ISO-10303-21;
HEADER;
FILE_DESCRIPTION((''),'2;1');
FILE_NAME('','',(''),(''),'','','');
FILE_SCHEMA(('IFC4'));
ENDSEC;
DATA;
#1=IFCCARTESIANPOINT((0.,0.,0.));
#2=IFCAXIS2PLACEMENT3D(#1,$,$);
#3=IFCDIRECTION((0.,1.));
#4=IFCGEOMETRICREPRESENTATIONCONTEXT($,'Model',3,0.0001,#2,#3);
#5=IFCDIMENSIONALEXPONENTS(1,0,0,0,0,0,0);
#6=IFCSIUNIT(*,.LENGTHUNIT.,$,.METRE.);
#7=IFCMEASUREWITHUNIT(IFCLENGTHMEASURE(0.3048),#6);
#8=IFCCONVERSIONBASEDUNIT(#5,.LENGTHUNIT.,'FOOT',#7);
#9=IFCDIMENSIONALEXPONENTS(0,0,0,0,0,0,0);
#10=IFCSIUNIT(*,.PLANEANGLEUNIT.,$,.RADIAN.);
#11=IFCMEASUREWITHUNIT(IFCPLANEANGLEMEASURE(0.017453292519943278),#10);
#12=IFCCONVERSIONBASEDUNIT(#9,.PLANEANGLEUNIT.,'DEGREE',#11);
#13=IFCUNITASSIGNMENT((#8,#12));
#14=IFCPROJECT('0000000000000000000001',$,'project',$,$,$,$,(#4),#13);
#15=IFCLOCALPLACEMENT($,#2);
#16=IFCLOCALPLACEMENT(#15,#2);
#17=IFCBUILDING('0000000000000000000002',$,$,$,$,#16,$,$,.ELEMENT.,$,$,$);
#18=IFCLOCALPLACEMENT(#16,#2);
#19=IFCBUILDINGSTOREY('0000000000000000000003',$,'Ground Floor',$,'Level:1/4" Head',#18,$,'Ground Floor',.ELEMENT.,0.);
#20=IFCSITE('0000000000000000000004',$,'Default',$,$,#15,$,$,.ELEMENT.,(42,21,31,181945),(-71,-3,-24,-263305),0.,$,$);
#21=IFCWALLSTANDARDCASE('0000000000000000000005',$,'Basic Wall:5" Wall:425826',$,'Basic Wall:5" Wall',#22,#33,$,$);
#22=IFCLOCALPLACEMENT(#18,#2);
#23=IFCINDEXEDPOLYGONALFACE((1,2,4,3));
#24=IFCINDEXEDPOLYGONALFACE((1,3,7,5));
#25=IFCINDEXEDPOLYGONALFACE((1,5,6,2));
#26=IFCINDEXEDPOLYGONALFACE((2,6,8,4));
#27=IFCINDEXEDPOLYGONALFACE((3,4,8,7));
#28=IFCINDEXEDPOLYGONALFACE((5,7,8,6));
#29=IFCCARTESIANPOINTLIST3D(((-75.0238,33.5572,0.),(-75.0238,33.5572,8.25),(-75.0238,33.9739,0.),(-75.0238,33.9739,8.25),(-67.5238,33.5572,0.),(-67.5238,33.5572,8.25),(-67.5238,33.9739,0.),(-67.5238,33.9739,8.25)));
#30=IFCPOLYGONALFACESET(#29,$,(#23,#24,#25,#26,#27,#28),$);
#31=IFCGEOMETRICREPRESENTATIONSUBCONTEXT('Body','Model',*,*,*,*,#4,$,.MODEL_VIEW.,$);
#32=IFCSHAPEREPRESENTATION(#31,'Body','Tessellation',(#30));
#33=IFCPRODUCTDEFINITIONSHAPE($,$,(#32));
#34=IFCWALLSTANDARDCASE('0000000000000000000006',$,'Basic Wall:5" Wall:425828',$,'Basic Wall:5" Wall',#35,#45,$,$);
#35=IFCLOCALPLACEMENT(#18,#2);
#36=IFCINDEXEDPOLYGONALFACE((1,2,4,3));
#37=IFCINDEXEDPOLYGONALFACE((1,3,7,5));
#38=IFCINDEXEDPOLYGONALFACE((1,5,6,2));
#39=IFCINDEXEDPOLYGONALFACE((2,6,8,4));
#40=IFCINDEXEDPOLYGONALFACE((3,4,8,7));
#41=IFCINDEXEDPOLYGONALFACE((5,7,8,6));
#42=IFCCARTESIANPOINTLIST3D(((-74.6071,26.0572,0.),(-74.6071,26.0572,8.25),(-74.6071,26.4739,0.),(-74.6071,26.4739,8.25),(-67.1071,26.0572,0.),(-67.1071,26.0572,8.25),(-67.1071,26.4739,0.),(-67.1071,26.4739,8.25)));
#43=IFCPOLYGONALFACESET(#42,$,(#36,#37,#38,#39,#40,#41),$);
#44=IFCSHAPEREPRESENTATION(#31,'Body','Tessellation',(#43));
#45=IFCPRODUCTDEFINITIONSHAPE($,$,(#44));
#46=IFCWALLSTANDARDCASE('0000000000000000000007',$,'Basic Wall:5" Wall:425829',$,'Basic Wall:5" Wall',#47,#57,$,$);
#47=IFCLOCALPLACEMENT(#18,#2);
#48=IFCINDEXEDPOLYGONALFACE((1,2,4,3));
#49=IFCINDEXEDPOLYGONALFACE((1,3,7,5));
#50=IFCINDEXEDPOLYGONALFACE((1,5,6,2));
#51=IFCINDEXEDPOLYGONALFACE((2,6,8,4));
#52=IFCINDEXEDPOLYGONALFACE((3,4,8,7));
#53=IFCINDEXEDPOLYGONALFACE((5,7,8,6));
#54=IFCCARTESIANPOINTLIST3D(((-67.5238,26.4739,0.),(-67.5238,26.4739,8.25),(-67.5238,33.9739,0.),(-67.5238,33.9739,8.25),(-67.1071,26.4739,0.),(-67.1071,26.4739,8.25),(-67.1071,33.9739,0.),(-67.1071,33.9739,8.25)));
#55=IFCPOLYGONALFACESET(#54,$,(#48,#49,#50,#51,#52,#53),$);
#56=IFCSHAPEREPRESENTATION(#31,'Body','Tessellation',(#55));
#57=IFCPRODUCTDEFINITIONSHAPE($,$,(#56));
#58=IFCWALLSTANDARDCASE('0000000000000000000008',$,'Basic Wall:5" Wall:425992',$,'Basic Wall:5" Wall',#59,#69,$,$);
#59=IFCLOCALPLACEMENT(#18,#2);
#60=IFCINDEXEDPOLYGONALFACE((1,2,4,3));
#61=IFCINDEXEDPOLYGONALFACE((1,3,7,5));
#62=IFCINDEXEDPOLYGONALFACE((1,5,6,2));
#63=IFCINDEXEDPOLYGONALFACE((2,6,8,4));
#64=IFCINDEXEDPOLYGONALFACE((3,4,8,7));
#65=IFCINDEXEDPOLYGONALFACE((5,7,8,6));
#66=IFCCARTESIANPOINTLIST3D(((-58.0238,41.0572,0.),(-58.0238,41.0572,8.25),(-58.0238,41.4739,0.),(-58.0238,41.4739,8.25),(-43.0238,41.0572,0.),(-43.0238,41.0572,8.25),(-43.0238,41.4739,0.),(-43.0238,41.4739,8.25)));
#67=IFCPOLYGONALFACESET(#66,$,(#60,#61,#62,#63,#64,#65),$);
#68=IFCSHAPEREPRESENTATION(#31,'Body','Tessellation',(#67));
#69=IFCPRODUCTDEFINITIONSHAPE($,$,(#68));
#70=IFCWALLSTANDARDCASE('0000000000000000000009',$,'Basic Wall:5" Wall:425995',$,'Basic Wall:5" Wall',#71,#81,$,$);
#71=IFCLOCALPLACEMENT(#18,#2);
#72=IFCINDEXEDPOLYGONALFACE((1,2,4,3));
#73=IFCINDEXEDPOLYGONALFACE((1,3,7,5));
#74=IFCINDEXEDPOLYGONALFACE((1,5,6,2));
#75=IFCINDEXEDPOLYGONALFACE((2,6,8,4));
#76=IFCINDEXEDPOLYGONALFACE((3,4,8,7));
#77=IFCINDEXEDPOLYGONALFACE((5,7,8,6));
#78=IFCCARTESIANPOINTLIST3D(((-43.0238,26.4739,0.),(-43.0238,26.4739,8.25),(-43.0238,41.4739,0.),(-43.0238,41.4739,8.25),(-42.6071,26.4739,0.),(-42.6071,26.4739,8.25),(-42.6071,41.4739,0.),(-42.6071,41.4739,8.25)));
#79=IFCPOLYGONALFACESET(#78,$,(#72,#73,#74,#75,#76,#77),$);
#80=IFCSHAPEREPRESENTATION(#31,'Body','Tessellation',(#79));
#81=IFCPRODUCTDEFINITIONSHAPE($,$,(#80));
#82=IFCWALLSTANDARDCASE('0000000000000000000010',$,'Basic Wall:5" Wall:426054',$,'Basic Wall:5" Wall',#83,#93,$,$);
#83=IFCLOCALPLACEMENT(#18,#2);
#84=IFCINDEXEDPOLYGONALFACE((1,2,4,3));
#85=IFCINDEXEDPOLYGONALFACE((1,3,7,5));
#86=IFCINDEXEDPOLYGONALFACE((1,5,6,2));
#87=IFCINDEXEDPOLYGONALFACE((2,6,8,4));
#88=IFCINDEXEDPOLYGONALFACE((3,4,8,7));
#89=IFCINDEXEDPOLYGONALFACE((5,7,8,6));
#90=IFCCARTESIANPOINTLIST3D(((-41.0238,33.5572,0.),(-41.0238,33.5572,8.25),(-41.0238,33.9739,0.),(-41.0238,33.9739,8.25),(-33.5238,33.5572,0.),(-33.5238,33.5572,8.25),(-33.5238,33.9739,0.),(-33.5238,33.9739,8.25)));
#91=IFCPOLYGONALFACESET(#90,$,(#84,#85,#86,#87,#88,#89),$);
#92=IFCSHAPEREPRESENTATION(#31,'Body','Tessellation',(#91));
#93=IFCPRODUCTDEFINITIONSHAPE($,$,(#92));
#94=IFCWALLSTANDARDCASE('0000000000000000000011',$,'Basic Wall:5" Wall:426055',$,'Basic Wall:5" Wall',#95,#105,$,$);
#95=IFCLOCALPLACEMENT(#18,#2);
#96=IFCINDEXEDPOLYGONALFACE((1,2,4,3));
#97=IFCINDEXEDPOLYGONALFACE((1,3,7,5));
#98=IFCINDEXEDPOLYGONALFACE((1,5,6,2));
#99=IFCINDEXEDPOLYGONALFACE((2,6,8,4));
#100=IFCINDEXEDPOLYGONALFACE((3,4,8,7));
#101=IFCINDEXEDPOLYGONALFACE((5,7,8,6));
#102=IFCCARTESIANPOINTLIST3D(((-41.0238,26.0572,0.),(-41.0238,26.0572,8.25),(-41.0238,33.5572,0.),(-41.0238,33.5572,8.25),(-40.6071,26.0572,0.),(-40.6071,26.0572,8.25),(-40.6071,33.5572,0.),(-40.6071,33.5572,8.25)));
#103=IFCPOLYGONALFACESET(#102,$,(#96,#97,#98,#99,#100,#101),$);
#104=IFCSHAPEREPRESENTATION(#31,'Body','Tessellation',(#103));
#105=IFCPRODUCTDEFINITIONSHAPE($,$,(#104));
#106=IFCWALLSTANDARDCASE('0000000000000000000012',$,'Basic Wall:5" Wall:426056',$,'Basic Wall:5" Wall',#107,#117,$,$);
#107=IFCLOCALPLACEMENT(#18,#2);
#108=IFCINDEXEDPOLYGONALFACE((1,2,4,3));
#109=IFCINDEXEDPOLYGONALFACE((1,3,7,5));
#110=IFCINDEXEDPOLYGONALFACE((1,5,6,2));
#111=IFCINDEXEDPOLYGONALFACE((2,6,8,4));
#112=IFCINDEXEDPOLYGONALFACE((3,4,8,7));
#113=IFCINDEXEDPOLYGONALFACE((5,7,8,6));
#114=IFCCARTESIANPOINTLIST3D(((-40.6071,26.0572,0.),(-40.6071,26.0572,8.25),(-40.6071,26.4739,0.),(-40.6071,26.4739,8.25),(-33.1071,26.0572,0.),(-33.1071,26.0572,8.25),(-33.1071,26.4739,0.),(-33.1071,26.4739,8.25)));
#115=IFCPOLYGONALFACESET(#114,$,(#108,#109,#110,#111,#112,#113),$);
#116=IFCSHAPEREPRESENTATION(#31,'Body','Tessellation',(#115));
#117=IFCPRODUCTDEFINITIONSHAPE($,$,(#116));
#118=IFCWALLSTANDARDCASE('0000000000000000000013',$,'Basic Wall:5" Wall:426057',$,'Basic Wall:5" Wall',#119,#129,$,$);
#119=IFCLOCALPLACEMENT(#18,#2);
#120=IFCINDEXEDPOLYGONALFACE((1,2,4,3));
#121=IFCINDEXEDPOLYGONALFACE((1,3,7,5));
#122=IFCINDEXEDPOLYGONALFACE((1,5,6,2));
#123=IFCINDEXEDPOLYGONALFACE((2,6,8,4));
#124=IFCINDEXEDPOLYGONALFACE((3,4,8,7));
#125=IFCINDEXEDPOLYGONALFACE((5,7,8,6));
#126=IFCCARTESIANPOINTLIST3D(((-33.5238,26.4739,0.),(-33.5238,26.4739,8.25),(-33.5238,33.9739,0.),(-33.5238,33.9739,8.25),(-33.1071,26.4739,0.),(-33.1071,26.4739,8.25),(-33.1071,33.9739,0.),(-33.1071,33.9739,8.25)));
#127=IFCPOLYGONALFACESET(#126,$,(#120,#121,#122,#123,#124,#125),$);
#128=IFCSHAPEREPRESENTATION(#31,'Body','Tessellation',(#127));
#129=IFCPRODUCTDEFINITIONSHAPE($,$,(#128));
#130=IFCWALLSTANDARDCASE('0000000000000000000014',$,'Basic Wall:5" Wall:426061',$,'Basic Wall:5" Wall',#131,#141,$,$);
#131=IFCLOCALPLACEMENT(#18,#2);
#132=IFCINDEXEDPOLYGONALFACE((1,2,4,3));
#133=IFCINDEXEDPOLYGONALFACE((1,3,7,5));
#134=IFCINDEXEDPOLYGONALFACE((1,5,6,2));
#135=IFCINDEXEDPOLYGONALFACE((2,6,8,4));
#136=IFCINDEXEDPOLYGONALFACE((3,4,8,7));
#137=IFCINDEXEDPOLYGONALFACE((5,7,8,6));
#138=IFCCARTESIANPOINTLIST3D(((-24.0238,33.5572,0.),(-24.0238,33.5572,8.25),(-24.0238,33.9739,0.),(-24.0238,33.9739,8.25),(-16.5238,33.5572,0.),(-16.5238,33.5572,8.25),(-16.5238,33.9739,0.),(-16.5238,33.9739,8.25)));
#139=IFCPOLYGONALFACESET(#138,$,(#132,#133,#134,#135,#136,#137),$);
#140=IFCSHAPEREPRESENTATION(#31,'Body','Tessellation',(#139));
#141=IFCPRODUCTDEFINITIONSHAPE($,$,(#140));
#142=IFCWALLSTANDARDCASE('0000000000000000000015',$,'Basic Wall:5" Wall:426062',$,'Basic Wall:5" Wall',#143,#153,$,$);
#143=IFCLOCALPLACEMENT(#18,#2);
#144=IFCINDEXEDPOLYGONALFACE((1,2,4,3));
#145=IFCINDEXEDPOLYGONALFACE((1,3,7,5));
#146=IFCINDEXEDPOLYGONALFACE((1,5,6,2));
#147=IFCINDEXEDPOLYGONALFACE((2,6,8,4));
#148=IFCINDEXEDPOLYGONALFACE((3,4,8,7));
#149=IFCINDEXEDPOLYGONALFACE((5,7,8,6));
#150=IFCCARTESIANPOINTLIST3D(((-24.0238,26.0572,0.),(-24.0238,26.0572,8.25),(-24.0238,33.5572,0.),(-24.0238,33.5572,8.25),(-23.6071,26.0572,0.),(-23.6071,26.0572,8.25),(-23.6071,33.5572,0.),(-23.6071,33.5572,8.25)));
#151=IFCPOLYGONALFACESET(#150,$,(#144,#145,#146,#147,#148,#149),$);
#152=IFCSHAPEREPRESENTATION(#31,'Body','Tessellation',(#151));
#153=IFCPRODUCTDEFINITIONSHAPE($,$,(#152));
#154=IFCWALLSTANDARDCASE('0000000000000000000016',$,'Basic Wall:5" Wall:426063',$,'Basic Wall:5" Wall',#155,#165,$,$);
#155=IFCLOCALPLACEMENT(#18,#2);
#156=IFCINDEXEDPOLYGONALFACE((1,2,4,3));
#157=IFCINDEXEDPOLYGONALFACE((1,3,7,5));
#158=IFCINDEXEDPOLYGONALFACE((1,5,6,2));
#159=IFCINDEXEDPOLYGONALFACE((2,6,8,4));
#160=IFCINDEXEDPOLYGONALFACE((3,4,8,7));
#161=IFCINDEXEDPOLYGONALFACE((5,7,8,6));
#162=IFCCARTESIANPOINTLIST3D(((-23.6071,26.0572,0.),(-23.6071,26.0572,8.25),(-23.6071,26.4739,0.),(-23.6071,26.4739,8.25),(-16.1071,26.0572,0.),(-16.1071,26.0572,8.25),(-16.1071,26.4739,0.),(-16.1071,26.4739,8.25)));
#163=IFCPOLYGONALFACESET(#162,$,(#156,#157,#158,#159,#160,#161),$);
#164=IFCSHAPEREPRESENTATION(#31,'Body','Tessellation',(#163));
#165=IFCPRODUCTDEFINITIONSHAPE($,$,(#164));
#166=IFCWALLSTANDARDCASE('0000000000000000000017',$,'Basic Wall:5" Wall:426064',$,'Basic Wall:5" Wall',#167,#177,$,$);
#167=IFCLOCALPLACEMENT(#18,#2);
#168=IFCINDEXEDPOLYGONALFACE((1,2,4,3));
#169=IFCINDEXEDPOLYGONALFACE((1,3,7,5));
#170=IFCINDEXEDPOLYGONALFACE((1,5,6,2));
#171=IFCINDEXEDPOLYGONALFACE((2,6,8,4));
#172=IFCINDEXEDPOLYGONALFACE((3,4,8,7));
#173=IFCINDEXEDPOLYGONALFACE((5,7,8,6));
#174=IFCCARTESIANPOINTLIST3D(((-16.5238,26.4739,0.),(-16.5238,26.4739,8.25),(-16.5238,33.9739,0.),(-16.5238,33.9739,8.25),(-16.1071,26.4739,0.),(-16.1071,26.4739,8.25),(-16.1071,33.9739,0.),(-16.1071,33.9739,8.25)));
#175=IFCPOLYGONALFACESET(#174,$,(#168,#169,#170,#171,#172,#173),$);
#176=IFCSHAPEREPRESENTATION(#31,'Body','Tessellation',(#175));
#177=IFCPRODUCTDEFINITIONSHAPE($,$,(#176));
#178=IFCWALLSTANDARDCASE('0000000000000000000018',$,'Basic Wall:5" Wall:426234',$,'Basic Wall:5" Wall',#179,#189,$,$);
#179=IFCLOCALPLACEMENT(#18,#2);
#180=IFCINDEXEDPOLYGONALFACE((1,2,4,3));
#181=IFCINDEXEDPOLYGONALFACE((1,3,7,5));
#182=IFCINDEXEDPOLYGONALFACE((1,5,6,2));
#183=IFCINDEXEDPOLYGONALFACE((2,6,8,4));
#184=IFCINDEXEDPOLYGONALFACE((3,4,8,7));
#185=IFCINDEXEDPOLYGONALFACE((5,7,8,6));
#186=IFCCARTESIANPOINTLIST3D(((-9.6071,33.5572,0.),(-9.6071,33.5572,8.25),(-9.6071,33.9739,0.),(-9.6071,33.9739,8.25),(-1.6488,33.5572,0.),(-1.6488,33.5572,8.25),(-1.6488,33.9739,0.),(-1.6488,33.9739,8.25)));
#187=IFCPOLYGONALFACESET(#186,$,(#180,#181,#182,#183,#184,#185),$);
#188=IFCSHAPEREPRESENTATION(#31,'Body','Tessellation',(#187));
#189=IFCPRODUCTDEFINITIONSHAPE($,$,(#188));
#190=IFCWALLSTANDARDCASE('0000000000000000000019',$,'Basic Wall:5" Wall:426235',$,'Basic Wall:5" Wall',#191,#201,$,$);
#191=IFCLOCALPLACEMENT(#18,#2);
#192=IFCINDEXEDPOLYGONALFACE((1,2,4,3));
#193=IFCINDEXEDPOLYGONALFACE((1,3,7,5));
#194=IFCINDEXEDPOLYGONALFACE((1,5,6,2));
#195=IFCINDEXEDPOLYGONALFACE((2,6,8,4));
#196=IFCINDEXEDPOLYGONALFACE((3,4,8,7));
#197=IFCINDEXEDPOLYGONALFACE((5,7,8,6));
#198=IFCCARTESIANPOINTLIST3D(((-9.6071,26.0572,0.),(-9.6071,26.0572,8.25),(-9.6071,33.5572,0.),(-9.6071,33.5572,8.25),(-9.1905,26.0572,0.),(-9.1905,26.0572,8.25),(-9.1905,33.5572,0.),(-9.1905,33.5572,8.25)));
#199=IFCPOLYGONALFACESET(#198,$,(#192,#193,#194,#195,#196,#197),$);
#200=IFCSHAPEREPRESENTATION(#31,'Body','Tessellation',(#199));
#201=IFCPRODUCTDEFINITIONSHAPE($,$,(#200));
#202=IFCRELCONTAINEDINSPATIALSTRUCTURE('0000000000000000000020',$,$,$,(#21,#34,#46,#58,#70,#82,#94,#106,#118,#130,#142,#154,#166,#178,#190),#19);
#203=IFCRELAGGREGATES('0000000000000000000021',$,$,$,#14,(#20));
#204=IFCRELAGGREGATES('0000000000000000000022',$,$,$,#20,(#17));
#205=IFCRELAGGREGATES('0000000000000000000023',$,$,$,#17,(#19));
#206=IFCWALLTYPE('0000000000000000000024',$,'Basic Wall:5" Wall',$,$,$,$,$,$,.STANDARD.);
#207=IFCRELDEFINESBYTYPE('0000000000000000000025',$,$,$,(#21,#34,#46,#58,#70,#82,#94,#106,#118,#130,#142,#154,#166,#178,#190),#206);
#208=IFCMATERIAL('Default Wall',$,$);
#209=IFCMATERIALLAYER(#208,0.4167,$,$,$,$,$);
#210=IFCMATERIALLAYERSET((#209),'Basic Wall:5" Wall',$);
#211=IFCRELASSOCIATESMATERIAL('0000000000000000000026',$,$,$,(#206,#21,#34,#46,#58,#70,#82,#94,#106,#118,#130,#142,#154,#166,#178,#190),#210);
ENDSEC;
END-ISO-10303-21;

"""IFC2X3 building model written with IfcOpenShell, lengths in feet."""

from ifc_helpers import new_model, entity, si_unit, converted_unit, direction, frame, frame_2d, origin, place, context, subcontext, project, spatial, rectangle, extrude, material, layer, layer_set, layer_usage, type_object, element, save


model = new_model("IFC2X3")

# Units and contexts
model_context = context("Model", 3, precision=0.0001, world=origin(), true_north=direction((0.0, 1.0)))
body_context = subcontext(model_context, "Body", "Model", "MODEL_VIEW")
ifc_project = project(units=[converted_unit("LENGTHUNIT", "FOOT", entity("IfcLengthMeasure", 0.3048), si_unit("LENGTHUNIT", "METRE"), dimensions=[1, 0, 0, 0, 0, 0, 0]), converted_unit("PLANEANGLEUNIT", "DEGREE", entity("IfcPlaneAngleMeasure", 0.017453292519943278), si_unit("PLANEANGLEUNIT", "RADIAN"), dimensions=[0, 0, 0, 0, 0, 0, 0])], contexts=[model_context])

# Site, building, storey
site_placement = place(None, origin())
site = spatial("IfcSite", under=ifc_project, at=site_placement, Name="Default", CompositionType="ELEMENT", RefLatitude=(42, 21, 31, 181945), RefLongitude=(-71, -3, -24, -263305), RefElevation=0.0)
building_placement = place(site_placement, origin())
building = spatial("IfcBuilding", under=site, at=building_placement, CompositionType="ELEMENT")
storey_placement = place(building_placement, origin())
storey = spatial("IfcBuildingStorey", under=building, at=storey_placement, Name="Ground Floor", ObjectType="Level:1/4\" Head", LongName="Ground Floor", CompositionType="ELEMENT", Elevation=0.0)

# Walls
ifc_material = material(Name="Default Wall")
ifc_layer = layer(ifc_material, 0.4167)
ifc_layer_set = layer_set([ifc_layer], Name="Basic Wall:5\" Wall")
ifc_layer_usage_1 = layer_usage(ifc_layer_set, "AXIS2", "NEGATIVE", 0.2083)
wall_type = type_object("IfcWallType", Name="Basic Wall:5\" Wall", PredefinedType="STANDARD", material=ifc_layer_set)
wall_1_placement = place(storey_placement, frame((-75.0238, 33.7656, 0.0)))
element("IfcWallStandardCase", 1, at=wall_1_placement, inside=storey, type_object=wall_type, material=ifc_layer_usage_1, Name="Basic Wall:5\" Wall:425826", ObjectType="Basic Wall:5\" Wall", context=body_context, shape_type="SweptSolid", body=[
    extrude(rectangle(XDim=7.5, YDim=0.4167, at=frame_2d((3.75, 0.0), x_axis=(-1.0, 0.0))), origin(), (0.0, 0.0, 1.0), 8.25),
])
wall_2_placement = place(storey_placement, frame((-67.1071, 26.2656, 0.0), z_axis=(0.0, 0.0, 1.0), x_axis=(-1.0, 0.0, 0.0)))
element("IfcWallStandardCase", 2, at=wall_2_placement, inside=storey, type_object=wall_type, material=ifc_layer_usage_1, Name="Basic Wall:5\" Wall:425828", ObjectType="Basic Wall:5\" Wall", context=body_context, shape_type="SweptSolid", body=[
    extrude(rectangle(XDim=7.5, YDim=0.4167, at=frame_2d((3.75, 0.0), x_axis=(-1.0, 0.0))), origin(), (0.0, 0.0, 1.0), 8.25),
])
wall_3_placement = place(storey_placement, frame((-67.3155, 33.9739, 0.0), z_axis=(0.0, 0.0, 1.0), x_axis=(0.0, -1.0, 0.0)))
element("IfcWallStandardCase", 3, at=wall_3_placement, inside=storey, type_object=wall_type, material=ifc_layer_usage_1, Name="Basic Wall:5\" Wall:425829", ObjectType="Basic Wall:5\" Wall", context=body_context, shape_type="SweptSolid", body=[
    extrude(rectangle(XDim=7.5, YDim=0.4167, at=frame_2d((3.75, 0.0), x_axis=(-1.0, 0.0))), origin(), (0.0, 0.0, 1.0), 8.25),
])
wall_4_placement = place(storey_placement, frame((-58.0238, 41.2656, 0.0)))
element("IfcWallStandardCase", 4, at=wall_4_placement, inside=storey, type_object=wall_type, material=ifc_layer_usage_1, Name="Basic Wall:5\" Wall:425992", ObjectType="Basic Wall:5\" Wall", context=body_context, shape_type="SweptSolid", body=[
    extrude(rectangle(XDim=15.0, YDim=0.4167, at=frame_2d((7.5, 0.0), x_axis=(-1.0, 0.0))), origin(), (0.0, 0.0, 1.0), 8.25),
])
wall_5_placement = place(storey_placement, frame((-42.8155, 41.4739, 0.0), z_axis=(0.0, 0.0, 1.0), x_axis=(0.0, -1.0, 0.0)))
element("IfcWallStandardCase", 5, at=wall_5_placement, inside=storey, type_object=wall_type, material=ifc_layer_usage_1, Name="Basic Wall:5\" Wall:425995", ObjectType="Basic Wall:5\" Wall", context=body_context, shape_type="SweptSolid", body=[
    extrude(rectangle(XDim=15.0, YDim=0.4167, at=frame_2d((7.5, 0.0), x_axis=(-1.0, 0.0))), origin(), (0.0, 0.0, 1.0), 8.25),
])
wall_6_placement = place(storey_placement, frame((-41.0238, 33.7656, 0.0)))
element("IfcWallStandardCase", 6, at=wall_6_placement, inside=storey, type_object=wall_type, material=ifc_layer_usage_1, Name="Basic Wall:5\" Wall:426054", ObjectType="Basic Wall:5\" Wall", context=body_context, shape_type="SweptSolid", body=[
    extrude(rectangle(XDim=7.5, YDim=0.4167, at=frame_2d((3.75, 0.0), x_axis=(-1.0, 0.0))), origin(), (0.0, 0.0, 1.0), 8.25),
])
wall_7_placement = place(storey_placement, frame((-40.8155, 26.0572, 0.0), z_axis=(0.0, 0.0, 1.0), x_axis=(0.0, 1.0, 0.0)))
element("IfcWallStandardCase", 7, at=wall_7_placement, inside=storey, type_object=wall_type, material=ifc_layer_usage_1, Name="Basic Wall:5\" Wall:426055", ObjectType="Basic Wall:5\" Wall", context=body_context, shape_type="SweptSolid", body=[
    extrude(rectangle(XDim=7.5, YDim=0.4167, at=frame_2d((3.75, 0.0), x_axis=(-1.0, 0.0))), origin(), (0.0, 0.0, 1.0), 8.25),
])
wall_8_placement = place(storey_placement, frame((-33.1071, 26.2656, 0.0), z_axis=(0.0, 0.0, 1.0), x_axis=(-1.0, 0.0, 0.0)))
element("IfcWallStandardCase", 8, at=wall_8_placement, inside=storey, type_object=wall_type, material=ifc_layer_usage_1, Name="Basic Wall:5\" Wall:426056", ObjectType="Basic Wall:5\" Wall", context=body_context, shape_type="SweptSolid", body=[
    extrude(rectangle(XDim=7.5, YDim=0.4167, at=frame_2d((3.75, 0.0), x_axis=(-1.0, 0.0))), origin(), (0.0, 0.0, 1.0), 8.25),
])
wall_9_placement = place(storey_placement, frame((-33.3155, 33.9739, 0.0), z_axis=(0.0, 0.0, 1.0), x_axis=(0.0, -1.0, 0.0)))
element("IfcWallStandardCase", 9, at=wall_9_placement, inside=storey, type_object=wall_type, material=ifc_layer_usage_1, Name="Basic Wall:5\" Wall:426057", ObjectType="Basic Wall:5\" Wall", context=body_context, shape_type="SweptSolid", body=[
    extrude(rectangle(XDim=7.5, YDim=0.4167, at=frame_2d((3.75, 0.0), x_axis=(-1.0, 0.0))), origin(), (0.0, 0.0, 1.0), 8.25),
])
wall_10_placement = place(storey_placement, frame((-24.0238, 33.7656, 0.0)))
element("IfcWallStandardCase", 10, at=wall_10_placement, inside=storey, type_object=wall_type, material=ifc_layer_usage_1, Name="Basic Wall:5\" Wall:426061", ObjectType="Basic Wall:5\" Wall", context=body_context, shape_type="SweptSolid", body=[
    extrude(rectangle(XDim=7.5, YDim=0.4167, at=frame_2d((3.75, 0.0), x_axis=(-1.0, 0.0))), origin(), (0.0, 0.0, 1.0), 8.25),
])
wall_11_placement = place(storey_placement, frame((-23.8155, 26.0572, 0.0), z_axis=(0.0, 0.0, 1.0), x_axis=(0.0, 1.0, 0.0)))
element("IfcWallStandardCase", 11, at=wall_11_placement, inside=storey, type_object=wall_type, material=ifc_layer_usage_1, Name="Basic Wall:5\" Wall:426062", ObjectType="Basic Wall:5\" Wall", context=body_context, shape_type="SweptSolid", body=[
    extrude(rectangle(XDim=7.5, YDim=0.4167, at=frame_2d((3.75, 0.0), x_axis=(-1.0, 0.0))), origin(), (0.0, 0.0, 1.0), 8.25),
])
wall_12_placement = place(storey_placement, frame((-16.1071, 26.2656, 0.0), z_axis=(0.0, 0.0, 1.0), x_axis=(-1.0, 0.0, 0.0)))
element("IfcWallStandardCase", 12, at=wall_12_placement, inside=storey, type_object=wall_type, material=ifc_layer_usage_1, Name="Basic Wall:5\" Wall:426063", ObjectType="Basic Wall:5\" Wall", context=body_context, shape_type="SweptSolid", body=[
    extrude(rectangle(XDim=7.5, YDim=0.4167, at=frame_2d((3.75, 0.0), x_axis=(-1.0, 0.0))), origin(), (0.0, 0.0, 1.0), 8.25),
])
wall_13_placement = place(storey_placement, frame((-16.3155, 33.9739, 0.0), z_axis=(0.0, 0.0, 1.0), x_axis=(0.0, -1.0, 0.0)))
element("IfcWallStandardCase", 13, at=wall_13_placement, inside=storey, type_object=wall_type, material=ifc_layer_usage_1, Name="Basic Wall:5\" Wall:426064", ObjectType="Basic Wall:5\" Wall", context=body_context, shape_type="SweptSolid", body=[
    extrude(rectangle(XDim=7.5, YDim=0.4167, at=frame_2d((3.75, 0.0), x_axis=(-1.0, 0.0))), origin(), (0.0, 0.0, 1.0), 8.25),
])
wall_14_placement = place(storey_placement, frame((-9.6071, 33.7656, 0.0)))
element("IfcWallStandardCase", 14, at=wall_14_placement, inside=storey, type_object=wall_type, material=ifc_layer_usage_1, Name="Basic Wall:5\" Wall:426234", ObjectType="Basic Wall:5\" Wall", context=body_context, shape_type="SweptSolid", body=[
    extrude(rectangle(XDim=7.9583, YDim=0.4167, at=frame_2d((3.9792, 0.0), x_axis=(-1.0, 0.0))), origin(), (0.0, 0.0, 1.0), 8.25),
])
ifc_layer_usage_2 = layer_usage(ifc_layer_set, "AXIS2", "POSITIVE", -0.2083)
wall_15_placement = place(storey_placement, frame((-9.3988, 26.0572, 0.0), z_axis=(0.0, 0.0, 1.0), x_axis=(0.0, 1.0, 0.0)))
element("IfcWallStandardCase", 15, at=wall_15_placement, inside=storey, type_object=wall_type, material=ifc_layer_usage_2, Name="Basic Wall:5\" Wall:426235", ObjectType="Basic Wall:5\" Wall", context=body_context, shape_type="SweptSolid", body=[
    extrude(rectangle(XDim=7.5, YDim=0.4167, at=frame_2d((3.75, 0.0), x_axis=(-1.0, 0.0))), origin(), (0.0, 0.0, 1.0), 8.25),
])

save(model, "model.ifc")
